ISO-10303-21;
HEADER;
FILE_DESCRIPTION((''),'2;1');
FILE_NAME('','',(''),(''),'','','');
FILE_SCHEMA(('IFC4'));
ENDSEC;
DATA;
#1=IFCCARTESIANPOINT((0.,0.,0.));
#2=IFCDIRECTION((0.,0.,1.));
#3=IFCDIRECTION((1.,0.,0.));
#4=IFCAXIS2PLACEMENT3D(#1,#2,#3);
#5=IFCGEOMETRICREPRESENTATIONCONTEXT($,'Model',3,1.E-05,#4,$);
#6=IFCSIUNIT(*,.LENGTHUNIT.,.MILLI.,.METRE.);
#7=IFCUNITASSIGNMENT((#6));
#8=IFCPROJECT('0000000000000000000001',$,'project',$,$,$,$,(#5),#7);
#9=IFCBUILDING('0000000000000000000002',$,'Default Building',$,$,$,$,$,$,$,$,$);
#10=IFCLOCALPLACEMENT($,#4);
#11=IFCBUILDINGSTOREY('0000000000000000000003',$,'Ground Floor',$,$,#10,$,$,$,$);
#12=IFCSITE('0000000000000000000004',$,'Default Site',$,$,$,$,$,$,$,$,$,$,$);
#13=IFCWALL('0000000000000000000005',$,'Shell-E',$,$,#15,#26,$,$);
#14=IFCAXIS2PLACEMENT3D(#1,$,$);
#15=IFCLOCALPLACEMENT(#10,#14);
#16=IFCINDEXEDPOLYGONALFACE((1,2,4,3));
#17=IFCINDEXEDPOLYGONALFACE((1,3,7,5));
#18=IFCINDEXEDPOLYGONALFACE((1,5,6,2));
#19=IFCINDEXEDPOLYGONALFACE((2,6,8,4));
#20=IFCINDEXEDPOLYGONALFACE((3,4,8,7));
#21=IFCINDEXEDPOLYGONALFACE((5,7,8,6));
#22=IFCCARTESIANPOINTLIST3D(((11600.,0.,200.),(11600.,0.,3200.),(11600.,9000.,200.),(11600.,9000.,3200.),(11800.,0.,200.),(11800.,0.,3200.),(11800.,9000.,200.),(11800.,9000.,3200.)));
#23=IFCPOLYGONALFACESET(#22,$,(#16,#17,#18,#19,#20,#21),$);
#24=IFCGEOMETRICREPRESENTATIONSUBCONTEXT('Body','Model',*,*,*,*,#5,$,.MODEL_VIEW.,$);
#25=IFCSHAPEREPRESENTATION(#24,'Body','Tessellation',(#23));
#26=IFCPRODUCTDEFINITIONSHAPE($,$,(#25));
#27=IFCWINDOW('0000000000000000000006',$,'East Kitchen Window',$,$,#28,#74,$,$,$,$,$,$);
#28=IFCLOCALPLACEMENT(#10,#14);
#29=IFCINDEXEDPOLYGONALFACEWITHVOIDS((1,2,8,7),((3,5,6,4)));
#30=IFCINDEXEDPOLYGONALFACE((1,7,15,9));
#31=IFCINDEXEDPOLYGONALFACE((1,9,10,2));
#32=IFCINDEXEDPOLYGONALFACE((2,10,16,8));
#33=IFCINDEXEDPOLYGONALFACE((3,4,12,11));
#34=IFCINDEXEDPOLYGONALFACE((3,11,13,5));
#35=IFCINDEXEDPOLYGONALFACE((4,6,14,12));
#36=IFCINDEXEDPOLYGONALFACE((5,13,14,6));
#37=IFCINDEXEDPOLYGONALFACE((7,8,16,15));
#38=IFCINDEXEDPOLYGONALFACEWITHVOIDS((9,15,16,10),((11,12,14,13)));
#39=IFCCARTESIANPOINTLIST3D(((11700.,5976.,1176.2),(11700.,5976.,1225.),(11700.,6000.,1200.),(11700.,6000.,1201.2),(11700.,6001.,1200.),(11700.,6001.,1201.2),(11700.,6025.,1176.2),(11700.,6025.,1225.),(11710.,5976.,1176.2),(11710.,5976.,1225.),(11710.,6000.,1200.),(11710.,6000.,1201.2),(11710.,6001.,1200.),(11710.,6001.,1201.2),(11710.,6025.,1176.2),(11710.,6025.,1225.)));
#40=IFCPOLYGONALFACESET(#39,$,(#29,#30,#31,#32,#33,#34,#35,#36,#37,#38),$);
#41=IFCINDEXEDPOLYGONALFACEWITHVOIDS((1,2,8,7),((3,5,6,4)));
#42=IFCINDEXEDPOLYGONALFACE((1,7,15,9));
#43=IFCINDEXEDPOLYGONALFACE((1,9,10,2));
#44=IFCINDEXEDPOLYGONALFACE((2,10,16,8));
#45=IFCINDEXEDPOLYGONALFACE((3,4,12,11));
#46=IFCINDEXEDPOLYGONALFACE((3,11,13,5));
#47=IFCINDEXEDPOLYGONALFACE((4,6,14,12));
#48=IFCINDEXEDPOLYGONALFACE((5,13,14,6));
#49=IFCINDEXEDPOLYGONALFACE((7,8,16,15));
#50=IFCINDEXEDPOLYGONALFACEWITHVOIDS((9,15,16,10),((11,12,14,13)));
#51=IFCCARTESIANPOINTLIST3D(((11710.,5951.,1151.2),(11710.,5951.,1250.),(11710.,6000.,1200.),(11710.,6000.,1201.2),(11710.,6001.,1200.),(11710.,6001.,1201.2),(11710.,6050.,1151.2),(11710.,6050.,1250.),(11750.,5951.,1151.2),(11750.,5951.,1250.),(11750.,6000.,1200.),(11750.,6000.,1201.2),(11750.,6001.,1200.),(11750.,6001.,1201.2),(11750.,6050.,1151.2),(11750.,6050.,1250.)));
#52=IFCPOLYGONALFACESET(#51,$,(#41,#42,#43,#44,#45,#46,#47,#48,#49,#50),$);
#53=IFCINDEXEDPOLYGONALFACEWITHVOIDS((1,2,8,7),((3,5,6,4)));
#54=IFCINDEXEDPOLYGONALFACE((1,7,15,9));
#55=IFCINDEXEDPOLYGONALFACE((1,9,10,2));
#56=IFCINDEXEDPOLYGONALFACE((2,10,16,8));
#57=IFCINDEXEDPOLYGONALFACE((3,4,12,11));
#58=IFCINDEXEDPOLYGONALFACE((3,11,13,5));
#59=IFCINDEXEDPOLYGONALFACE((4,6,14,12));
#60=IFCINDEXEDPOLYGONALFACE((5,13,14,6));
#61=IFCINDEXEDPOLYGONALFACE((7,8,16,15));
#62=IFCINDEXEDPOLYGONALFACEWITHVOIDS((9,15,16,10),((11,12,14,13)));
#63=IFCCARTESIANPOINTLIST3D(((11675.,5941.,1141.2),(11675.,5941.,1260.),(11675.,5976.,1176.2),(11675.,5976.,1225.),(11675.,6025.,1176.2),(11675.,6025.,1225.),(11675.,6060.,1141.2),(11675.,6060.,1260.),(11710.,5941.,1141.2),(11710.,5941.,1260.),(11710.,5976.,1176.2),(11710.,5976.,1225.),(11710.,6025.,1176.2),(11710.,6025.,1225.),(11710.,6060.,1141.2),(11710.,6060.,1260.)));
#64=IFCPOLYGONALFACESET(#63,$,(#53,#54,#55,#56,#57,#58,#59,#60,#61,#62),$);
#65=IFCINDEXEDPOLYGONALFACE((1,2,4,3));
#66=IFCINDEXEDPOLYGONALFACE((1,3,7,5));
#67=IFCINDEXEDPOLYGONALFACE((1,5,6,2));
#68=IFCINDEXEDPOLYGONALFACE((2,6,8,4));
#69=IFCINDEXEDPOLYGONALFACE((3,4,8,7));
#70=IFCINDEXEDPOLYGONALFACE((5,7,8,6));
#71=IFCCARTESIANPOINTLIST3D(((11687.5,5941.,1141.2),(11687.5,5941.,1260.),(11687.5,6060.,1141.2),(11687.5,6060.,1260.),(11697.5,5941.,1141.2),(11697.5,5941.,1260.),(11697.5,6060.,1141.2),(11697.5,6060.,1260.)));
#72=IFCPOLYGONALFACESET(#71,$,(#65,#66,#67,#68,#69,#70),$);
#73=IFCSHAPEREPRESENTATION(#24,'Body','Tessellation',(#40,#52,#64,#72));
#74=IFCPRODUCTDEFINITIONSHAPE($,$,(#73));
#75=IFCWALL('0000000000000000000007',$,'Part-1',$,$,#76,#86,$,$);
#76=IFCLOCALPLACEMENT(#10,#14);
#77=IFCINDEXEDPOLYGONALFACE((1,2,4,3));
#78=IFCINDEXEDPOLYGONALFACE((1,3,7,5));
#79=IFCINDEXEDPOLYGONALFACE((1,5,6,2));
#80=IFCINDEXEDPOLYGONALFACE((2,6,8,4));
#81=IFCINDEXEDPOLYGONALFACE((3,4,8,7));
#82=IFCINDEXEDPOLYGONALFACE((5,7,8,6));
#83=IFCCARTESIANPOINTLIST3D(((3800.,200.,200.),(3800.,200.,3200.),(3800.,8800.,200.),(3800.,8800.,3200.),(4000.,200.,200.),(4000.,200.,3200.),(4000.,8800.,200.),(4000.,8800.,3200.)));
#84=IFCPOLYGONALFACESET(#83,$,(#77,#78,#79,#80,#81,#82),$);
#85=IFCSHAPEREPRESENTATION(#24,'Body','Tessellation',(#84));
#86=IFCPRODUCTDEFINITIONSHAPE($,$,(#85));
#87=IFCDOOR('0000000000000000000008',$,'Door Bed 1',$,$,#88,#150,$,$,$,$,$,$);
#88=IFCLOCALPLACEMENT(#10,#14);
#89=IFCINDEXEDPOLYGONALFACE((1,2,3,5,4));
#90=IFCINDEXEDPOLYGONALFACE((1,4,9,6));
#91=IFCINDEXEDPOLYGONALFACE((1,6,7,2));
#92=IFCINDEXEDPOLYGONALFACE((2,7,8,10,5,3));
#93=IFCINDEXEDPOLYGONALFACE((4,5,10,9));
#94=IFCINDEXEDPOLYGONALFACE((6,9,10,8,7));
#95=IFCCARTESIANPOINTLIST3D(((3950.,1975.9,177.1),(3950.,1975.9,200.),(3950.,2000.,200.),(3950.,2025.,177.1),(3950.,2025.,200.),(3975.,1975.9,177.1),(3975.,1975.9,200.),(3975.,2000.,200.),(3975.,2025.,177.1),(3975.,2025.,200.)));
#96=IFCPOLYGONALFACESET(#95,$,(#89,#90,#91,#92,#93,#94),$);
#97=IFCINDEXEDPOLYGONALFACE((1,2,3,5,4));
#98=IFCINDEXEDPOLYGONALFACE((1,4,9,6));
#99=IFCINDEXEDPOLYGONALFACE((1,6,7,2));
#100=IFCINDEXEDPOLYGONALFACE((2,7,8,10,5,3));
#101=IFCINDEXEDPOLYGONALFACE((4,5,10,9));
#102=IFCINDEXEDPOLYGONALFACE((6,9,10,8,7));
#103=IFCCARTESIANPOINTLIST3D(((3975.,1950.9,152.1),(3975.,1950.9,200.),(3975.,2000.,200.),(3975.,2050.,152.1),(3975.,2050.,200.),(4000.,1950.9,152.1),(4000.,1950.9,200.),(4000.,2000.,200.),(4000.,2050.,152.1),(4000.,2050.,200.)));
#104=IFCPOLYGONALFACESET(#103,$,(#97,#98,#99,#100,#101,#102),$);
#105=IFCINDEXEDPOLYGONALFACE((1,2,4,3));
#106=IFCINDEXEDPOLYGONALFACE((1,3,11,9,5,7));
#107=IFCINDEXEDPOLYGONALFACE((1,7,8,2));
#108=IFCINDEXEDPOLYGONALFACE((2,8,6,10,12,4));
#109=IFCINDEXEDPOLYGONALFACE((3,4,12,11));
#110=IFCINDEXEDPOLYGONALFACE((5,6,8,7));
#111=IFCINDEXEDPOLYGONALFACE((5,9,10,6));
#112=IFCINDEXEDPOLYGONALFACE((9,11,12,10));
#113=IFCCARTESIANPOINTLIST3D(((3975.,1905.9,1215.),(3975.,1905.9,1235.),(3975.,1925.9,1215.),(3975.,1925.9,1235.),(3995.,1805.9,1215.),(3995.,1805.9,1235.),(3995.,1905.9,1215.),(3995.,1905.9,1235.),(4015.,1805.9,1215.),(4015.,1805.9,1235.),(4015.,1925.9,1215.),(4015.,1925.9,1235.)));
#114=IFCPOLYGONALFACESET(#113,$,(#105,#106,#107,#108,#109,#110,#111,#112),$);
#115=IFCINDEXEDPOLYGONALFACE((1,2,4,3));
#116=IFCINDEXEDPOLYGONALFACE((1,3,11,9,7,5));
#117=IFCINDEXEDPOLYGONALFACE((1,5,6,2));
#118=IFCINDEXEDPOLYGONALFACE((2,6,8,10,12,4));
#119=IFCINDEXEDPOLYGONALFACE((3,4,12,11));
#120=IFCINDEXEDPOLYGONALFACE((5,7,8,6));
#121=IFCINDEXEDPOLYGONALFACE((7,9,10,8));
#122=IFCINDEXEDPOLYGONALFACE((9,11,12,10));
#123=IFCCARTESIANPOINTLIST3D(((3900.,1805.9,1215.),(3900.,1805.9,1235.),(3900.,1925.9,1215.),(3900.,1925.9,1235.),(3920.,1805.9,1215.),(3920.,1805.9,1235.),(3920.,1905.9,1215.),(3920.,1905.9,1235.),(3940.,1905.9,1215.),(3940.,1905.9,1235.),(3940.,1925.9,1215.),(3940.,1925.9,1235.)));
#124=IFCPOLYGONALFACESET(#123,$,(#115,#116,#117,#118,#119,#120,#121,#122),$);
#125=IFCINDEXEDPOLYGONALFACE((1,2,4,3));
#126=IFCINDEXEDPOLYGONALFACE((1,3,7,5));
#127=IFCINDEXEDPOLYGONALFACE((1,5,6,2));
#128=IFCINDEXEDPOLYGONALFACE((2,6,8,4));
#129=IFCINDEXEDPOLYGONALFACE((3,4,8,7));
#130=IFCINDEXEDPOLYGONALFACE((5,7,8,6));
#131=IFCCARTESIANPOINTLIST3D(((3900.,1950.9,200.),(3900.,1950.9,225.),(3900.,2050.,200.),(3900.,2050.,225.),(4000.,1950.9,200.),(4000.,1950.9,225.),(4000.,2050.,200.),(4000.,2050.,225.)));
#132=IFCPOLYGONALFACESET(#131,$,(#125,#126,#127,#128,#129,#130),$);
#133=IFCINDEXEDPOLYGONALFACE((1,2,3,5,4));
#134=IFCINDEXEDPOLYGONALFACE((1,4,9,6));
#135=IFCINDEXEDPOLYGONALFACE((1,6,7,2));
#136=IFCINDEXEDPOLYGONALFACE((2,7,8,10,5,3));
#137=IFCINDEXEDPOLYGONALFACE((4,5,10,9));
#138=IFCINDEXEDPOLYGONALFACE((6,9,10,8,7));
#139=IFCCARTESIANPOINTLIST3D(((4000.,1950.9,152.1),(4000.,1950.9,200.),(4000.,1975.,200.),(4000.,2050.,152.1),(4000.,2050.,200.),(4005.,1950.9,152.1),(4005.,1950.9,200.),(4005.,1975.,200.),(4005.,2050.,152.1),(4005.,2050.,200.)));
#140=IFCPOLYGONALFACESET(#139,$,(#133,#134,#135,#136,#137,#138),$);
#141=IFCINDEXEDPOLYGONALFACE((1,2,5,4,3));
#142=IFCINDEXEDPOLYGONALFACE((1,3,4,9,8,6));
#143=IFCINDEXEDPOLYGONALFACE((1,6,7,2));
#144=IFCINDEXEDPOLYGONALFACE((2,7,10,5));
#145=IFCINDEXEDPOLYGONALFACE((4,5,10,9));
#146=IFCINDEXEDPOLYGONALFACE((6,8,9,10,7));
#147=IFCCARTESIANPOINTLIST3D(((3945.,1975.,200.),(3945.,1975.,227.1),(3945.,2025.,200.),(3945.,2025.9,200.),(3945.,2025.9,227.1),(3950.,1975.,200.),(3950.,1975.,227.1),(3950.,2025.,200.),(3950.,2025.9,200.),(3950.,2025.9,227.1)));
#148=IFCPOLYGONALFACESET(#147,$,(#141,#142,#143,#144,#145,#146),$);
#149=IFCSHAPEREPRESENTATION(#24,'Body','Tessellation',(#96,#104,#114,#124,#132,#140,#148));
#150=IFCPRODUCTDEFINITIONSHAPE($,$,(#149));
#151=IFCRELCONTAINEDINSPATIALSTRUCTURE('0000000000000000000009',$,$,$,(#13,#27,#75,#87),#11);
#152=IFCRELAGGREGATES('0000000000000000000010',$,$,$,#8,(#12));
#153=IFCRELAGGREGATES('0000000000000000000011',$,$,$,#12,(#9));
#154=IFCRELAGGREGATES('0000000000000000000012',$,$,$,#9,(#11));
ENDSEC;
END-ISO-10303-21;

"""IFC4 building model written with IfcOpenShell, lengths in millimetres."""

from ifc_helpers import new_model, si_unit, frame, origin_with_axes, place, context, subcontext, project, spatial, line, indexed_curve, outline, extrude, element, fill, save


model = new_model("IFC4")

# Units and contexts
model_context = context("Model", 3, precision=1e-05, world=origin_with_axes())
body_context = subcontext(model_context, "Body", "Model", "MODEL_VIEW")
ifc_project = project(units=[si_unit("LENGTHUNIT", "METRE", prefix="MILLI")], contexts=[model_context])

# Site, building, storey
site = spatial("IfcSite", under=ifc_project, Name="Default Site")
building = spatial("IfcBuilding", under=site, Name="Default Building")
storey_placement = place(None, origin_with_axes())
storey = spatial("IfcBuildingStorey", under=building, at=storey_placement, Name="Ground Floor")

# Wall, opening, window
wall_1_placement = place(storey_placement, frame((0.0, 0.0, 200.0), z_axis=(0.0, 0.0, 1.0), x_axis=(1.0, 0.0, 0.0)))
wall_1 = element("IfcWall", 1, at=wall_1_placement, inside=storey, Name="Shell-E", context=body_context, shape_type="SweptSolid", body=[
    extrude(outline(indexed_curve([(11800.0, 0.0), (11800.0, 9000.0), (11600.0, 9000.0), (11600.0, 0.0), (11800.0, 0.0)])), None, (0.0, 0.0, 1.0), 3000.0),
])
opening_1_placement = place(wall_1_placement, frame((0.0, 0.0, 1000.0), z_axis=(0.0, 0.0, 1.0), x_axis=(1.0, 0.0, 0.0)))
opening_1 = element("IfcOpeningElement", 2, at=opening_1_placement, cuts=wall_1, context=body_context, shape_type="SweptSolid", body=[
    extrude(outline(indexed_curve([(11800.0, 6000.0), (12000.0, 6000.0), (12000.0, 7000.0), (11800.0, 7000.0), (11800.0, 6000.0)])), None, (0.0, 0.0, 1.0), 1200.0),
])
window_1_placement = place(storey_placement, frame((11800.0, 6000.0, 1200.0), z_axis=(0.0, 0.0, 1.0), x_axis=(0.0, 1.0, 0.0)))
window_1 = element("IfcWindow", 3, at=window_1_placement, inside=storey, Name="East Kitchen Window", context=body_context, shape_type="SweptSolid", body=[
    extrude(outline(indexed_curve([(0.0, 0.0), (1.0, 0.0), (1.0, 1.2), (0.0, 1.2)], segments=[line(1, 2, 3, 4, 1)]), holes=[indexed_curve([(25.0, 25.0), (-24.0, 25.0), (-24.0, -23.8), (25.0, -23.8)], segments=[line(1, 2, 3, 4, 1)])]), frame((0.0, 90.0, 0.0), z_axis=(0.0, -1.0, 0.0), x_axis=(1.0, 0.0, 0.0)), (0.0, 0.0, -1.0), 10.0),
    extrude(outline(indexed_curve([(0.0, 0.0), (1.0, 0.0), (1.0, 1.2), (0.0, 1.2)], segments=[line(1, 2, 3, 4, 1)]), holes=[indexed_curve([(50.0, 50.0), (-49.0, 50.0), (-49.0, -48.8), (50.0, -48.8)], segments=[line(1, 2, 3, 4, 1)])]), frame((0.0, 50.0, 0.0), z_axis=(0.0, -1.0, 0.0), x_axis=(1.0, 0.0, 0.0)), (0.0, 0.0, -1.0), 40.0),
    extrude(outline(indexed_curve([(0.0, 0.0), (-49.0, 0.0), (-49.0, -48.8), (0.0, -48.8)], segments=[line(1, 2, 3, 4, 1)]), holes=[indexed_curve([(35.0, 35.0), (-84.0, 35.0), (-84.0, -83.8), (35.0, -83.8)], segments=[line(1, 2, 3, 4, 1)])]), frame((25.0, 90.0, 25.0), z_axis=(0.0, -1.0, 0.0), x_axis=(1.0, 0.0, 0.0)), (0.0, 0.0, -1.0), 35.0),
    extrude(outline(indexed_curve([(35.0, 35.0), (-84.0, 35.0), (-84.0, -83.8), (35.0, -83.8)], segments=[line(1, 2, 3, 4, 1)])), frame((25.0, 102.5, 25.0), z_axis=(0.0, -1.0, 0.0), x_axis=(1.0, 0.0, 0.0)), (0.0, 0.0, -1.0), 10.0),
])
fill(opening_1, window_1)

# Wall, opening, door
wall_2_placement = place(storey_placement, frame((0.0, 0.0, 200.0), z_axis=(0.0, 0.0, 1.0), x_axis=(1.0, 0.0, 0.0)))
wall_2 = element("IfcWall", 4, at=wall_2_placement, inside=storey, Name="Part-1", context=body_context, shape_type="SweptSolid", body=[
    extrude(outline(indexed_curve([(4000.0, 200.0), (4000.0, 8800.0), (3800.0, 8800.0), (3800.0, 200.0), (4000.0, 200.0)])), None, (0.0, 0.0, 1.0), 3000.0),
])
opening_2_placement = place(wall_2_placement, origin_with_axes())
opening_2 = element("IfcOpeningElement", 5, at=opening_2_placement, cuts=wall_2, context=body_context, shape_type="SweptSolid", body=[
    extrude(outline(indexed_curve([(4000.0, 2000.0), (4200.0, 2000.0), (4200.0, 2900.0), (4000.0, 2900.0), (4000.0, 2000.0)])), None, (0.0, 0.0, 1.0), 2100.0),
])
door_1_placement = place(storey_placement, frame((4000.0, 2000.0, 200.0), z_axis=(0.0, 0.0, 1.0), x_axis=(0.0, 1.0, 0.0)))
door_1 = element("IfcDoor", 6, at=door_1_placement, inside=storey, Name="Door Bed 1", context=body_context, shape_type="SweptSolid", body=[
    extrude(outline(indexed_curve([(0.0, 0.0), (0.0, 2.1), (0.9, 2.1), (0.9, 0.0), (-24.1, 0.0), (-24.1, -22.9), (25.0, -22.9), (25.0, 0.0)], segments=[line(1, 2, 3, 4, 5, 6, 7, 8, 1)])), frame((0.0, 25.0, 0.0), z_axis=(0.0, -1.0, 0.0), x_axis=(1.0, 0.0, 0.0)), (0.0, 0.0, -1.0), 25.0),
    extrude(outline(indexed_curve([(0.0, 0.0), (0.0, 2.1), (0.9, 2.1), (0.9, 0.0), (-49.1, 0.0), (-49.1, -47.9), (50.0, -47.9), (50.0, 0.0)], segments=[line(1, 2, 3, 4, 5, 6, 7, 8, 1)])), frame((0.0, 0.0, 0.0), z_axis=(0.0, -1.0, 0.0), x_axis=(1.0, 0.0, 0.0)), (0.0, 0.0, -1.0), 25.0),
    extrude(outline(indexed_curve([(0.0, 0.0), (-49.1, 0.0), (-49.1, 35.0), (0.0, 35.0)], segments=[line(1, 2, 3, 4, 1)])), frame((25.0, 25.0, 25.0), z_axis=(0.0, 0.0, 1.0), x_axis=(1.0, 0.0, 0.0)), (0.0, 0.0, 1.0), -47.9),
    extrude(outline(indexed_curve([(0.0, 0.0), (0.0, -40.0), (-120.0, -40.0), (-120.0, -20.0), (-20.0, -20.0), (-20.0, 0.0)], segments=[line(1, 2, 3, 4, 5, 6, 1)])), frame((-74.1, 25.0, 1015.0), z_axis=(0.0, 0.0, 1.0), x_axis=(1.0, 0.0, 0.0)), (0.0, 0.0, 1.0), 20.0),
    extrude(outline(indexed_curve([(0.0, 0.0), (0.0, 40.0), (-120.0, 40.0), (-120.0, 20.0), (-20.0, 20.0), (-20.0, 0.0)], segments=[line(1, 2, 3, 4, 5, 6, 1)])), frame((-74.1, 60.0, 1015.0), z_axis=(0.0, 0.0, 1.0), x_axis=(1.0, 0.0, 0.0)), (0.0, 0.0, 1.0), 20.0),
    extrude(outline(indexed_curve([(0.0, 0.0), (-99.1, 0.0), (-99.1, 100.0), (0.0, 100.0)], segments=[line(1, 2, 3, 4, 1)])), frame((50.0, 0.0, 0.0), z_axis=(0.0, 0.0, 1.0), x_axis=(1.0, 0.0, 0.0)), (0.0, 0.0, 1.0), 25.0),
    extrude(outline(indexed_curve([(0.0, 0.0), (0.0, 27.1), (50.9, 27.1), (50.9, 0.0), (-24.1, 0.0), (-24.1, -47.9), (75.0, -47.9), (75.0, 0.0)], segments=[line(1, 2, 3, 4, 5, 6, 7, 8, 1)])), frame((-25.0, -5.0, 0.0), z_axis=(0.0, -1.0, 0.0), x_axis=(1.0, 0.0, 0.0)), (0.0, 0.0, -1.0), 5.0),
    extrude(outline(indexed_curve([(0.0, 0.0), (0.0, 27.1), (50.9, 27.1), (50.9, 0.0), (0.9, 0.0), (0.9, -22.9), (50.0, -22.9), (50.0, 0.0)], segments=[line(1, 2, 3, 4, 5, 6, 7, 8, 1)])), frame((-25.0, 50.0, 0.0), z_axis=(0.0, -1.0, 0.0), x_axis=(1.0, 0.0, 0.0)), (0.0, 0.0, -1.0), 5.0),
])
fill(opening_2, door_1)

save(model, "model.ifc")
